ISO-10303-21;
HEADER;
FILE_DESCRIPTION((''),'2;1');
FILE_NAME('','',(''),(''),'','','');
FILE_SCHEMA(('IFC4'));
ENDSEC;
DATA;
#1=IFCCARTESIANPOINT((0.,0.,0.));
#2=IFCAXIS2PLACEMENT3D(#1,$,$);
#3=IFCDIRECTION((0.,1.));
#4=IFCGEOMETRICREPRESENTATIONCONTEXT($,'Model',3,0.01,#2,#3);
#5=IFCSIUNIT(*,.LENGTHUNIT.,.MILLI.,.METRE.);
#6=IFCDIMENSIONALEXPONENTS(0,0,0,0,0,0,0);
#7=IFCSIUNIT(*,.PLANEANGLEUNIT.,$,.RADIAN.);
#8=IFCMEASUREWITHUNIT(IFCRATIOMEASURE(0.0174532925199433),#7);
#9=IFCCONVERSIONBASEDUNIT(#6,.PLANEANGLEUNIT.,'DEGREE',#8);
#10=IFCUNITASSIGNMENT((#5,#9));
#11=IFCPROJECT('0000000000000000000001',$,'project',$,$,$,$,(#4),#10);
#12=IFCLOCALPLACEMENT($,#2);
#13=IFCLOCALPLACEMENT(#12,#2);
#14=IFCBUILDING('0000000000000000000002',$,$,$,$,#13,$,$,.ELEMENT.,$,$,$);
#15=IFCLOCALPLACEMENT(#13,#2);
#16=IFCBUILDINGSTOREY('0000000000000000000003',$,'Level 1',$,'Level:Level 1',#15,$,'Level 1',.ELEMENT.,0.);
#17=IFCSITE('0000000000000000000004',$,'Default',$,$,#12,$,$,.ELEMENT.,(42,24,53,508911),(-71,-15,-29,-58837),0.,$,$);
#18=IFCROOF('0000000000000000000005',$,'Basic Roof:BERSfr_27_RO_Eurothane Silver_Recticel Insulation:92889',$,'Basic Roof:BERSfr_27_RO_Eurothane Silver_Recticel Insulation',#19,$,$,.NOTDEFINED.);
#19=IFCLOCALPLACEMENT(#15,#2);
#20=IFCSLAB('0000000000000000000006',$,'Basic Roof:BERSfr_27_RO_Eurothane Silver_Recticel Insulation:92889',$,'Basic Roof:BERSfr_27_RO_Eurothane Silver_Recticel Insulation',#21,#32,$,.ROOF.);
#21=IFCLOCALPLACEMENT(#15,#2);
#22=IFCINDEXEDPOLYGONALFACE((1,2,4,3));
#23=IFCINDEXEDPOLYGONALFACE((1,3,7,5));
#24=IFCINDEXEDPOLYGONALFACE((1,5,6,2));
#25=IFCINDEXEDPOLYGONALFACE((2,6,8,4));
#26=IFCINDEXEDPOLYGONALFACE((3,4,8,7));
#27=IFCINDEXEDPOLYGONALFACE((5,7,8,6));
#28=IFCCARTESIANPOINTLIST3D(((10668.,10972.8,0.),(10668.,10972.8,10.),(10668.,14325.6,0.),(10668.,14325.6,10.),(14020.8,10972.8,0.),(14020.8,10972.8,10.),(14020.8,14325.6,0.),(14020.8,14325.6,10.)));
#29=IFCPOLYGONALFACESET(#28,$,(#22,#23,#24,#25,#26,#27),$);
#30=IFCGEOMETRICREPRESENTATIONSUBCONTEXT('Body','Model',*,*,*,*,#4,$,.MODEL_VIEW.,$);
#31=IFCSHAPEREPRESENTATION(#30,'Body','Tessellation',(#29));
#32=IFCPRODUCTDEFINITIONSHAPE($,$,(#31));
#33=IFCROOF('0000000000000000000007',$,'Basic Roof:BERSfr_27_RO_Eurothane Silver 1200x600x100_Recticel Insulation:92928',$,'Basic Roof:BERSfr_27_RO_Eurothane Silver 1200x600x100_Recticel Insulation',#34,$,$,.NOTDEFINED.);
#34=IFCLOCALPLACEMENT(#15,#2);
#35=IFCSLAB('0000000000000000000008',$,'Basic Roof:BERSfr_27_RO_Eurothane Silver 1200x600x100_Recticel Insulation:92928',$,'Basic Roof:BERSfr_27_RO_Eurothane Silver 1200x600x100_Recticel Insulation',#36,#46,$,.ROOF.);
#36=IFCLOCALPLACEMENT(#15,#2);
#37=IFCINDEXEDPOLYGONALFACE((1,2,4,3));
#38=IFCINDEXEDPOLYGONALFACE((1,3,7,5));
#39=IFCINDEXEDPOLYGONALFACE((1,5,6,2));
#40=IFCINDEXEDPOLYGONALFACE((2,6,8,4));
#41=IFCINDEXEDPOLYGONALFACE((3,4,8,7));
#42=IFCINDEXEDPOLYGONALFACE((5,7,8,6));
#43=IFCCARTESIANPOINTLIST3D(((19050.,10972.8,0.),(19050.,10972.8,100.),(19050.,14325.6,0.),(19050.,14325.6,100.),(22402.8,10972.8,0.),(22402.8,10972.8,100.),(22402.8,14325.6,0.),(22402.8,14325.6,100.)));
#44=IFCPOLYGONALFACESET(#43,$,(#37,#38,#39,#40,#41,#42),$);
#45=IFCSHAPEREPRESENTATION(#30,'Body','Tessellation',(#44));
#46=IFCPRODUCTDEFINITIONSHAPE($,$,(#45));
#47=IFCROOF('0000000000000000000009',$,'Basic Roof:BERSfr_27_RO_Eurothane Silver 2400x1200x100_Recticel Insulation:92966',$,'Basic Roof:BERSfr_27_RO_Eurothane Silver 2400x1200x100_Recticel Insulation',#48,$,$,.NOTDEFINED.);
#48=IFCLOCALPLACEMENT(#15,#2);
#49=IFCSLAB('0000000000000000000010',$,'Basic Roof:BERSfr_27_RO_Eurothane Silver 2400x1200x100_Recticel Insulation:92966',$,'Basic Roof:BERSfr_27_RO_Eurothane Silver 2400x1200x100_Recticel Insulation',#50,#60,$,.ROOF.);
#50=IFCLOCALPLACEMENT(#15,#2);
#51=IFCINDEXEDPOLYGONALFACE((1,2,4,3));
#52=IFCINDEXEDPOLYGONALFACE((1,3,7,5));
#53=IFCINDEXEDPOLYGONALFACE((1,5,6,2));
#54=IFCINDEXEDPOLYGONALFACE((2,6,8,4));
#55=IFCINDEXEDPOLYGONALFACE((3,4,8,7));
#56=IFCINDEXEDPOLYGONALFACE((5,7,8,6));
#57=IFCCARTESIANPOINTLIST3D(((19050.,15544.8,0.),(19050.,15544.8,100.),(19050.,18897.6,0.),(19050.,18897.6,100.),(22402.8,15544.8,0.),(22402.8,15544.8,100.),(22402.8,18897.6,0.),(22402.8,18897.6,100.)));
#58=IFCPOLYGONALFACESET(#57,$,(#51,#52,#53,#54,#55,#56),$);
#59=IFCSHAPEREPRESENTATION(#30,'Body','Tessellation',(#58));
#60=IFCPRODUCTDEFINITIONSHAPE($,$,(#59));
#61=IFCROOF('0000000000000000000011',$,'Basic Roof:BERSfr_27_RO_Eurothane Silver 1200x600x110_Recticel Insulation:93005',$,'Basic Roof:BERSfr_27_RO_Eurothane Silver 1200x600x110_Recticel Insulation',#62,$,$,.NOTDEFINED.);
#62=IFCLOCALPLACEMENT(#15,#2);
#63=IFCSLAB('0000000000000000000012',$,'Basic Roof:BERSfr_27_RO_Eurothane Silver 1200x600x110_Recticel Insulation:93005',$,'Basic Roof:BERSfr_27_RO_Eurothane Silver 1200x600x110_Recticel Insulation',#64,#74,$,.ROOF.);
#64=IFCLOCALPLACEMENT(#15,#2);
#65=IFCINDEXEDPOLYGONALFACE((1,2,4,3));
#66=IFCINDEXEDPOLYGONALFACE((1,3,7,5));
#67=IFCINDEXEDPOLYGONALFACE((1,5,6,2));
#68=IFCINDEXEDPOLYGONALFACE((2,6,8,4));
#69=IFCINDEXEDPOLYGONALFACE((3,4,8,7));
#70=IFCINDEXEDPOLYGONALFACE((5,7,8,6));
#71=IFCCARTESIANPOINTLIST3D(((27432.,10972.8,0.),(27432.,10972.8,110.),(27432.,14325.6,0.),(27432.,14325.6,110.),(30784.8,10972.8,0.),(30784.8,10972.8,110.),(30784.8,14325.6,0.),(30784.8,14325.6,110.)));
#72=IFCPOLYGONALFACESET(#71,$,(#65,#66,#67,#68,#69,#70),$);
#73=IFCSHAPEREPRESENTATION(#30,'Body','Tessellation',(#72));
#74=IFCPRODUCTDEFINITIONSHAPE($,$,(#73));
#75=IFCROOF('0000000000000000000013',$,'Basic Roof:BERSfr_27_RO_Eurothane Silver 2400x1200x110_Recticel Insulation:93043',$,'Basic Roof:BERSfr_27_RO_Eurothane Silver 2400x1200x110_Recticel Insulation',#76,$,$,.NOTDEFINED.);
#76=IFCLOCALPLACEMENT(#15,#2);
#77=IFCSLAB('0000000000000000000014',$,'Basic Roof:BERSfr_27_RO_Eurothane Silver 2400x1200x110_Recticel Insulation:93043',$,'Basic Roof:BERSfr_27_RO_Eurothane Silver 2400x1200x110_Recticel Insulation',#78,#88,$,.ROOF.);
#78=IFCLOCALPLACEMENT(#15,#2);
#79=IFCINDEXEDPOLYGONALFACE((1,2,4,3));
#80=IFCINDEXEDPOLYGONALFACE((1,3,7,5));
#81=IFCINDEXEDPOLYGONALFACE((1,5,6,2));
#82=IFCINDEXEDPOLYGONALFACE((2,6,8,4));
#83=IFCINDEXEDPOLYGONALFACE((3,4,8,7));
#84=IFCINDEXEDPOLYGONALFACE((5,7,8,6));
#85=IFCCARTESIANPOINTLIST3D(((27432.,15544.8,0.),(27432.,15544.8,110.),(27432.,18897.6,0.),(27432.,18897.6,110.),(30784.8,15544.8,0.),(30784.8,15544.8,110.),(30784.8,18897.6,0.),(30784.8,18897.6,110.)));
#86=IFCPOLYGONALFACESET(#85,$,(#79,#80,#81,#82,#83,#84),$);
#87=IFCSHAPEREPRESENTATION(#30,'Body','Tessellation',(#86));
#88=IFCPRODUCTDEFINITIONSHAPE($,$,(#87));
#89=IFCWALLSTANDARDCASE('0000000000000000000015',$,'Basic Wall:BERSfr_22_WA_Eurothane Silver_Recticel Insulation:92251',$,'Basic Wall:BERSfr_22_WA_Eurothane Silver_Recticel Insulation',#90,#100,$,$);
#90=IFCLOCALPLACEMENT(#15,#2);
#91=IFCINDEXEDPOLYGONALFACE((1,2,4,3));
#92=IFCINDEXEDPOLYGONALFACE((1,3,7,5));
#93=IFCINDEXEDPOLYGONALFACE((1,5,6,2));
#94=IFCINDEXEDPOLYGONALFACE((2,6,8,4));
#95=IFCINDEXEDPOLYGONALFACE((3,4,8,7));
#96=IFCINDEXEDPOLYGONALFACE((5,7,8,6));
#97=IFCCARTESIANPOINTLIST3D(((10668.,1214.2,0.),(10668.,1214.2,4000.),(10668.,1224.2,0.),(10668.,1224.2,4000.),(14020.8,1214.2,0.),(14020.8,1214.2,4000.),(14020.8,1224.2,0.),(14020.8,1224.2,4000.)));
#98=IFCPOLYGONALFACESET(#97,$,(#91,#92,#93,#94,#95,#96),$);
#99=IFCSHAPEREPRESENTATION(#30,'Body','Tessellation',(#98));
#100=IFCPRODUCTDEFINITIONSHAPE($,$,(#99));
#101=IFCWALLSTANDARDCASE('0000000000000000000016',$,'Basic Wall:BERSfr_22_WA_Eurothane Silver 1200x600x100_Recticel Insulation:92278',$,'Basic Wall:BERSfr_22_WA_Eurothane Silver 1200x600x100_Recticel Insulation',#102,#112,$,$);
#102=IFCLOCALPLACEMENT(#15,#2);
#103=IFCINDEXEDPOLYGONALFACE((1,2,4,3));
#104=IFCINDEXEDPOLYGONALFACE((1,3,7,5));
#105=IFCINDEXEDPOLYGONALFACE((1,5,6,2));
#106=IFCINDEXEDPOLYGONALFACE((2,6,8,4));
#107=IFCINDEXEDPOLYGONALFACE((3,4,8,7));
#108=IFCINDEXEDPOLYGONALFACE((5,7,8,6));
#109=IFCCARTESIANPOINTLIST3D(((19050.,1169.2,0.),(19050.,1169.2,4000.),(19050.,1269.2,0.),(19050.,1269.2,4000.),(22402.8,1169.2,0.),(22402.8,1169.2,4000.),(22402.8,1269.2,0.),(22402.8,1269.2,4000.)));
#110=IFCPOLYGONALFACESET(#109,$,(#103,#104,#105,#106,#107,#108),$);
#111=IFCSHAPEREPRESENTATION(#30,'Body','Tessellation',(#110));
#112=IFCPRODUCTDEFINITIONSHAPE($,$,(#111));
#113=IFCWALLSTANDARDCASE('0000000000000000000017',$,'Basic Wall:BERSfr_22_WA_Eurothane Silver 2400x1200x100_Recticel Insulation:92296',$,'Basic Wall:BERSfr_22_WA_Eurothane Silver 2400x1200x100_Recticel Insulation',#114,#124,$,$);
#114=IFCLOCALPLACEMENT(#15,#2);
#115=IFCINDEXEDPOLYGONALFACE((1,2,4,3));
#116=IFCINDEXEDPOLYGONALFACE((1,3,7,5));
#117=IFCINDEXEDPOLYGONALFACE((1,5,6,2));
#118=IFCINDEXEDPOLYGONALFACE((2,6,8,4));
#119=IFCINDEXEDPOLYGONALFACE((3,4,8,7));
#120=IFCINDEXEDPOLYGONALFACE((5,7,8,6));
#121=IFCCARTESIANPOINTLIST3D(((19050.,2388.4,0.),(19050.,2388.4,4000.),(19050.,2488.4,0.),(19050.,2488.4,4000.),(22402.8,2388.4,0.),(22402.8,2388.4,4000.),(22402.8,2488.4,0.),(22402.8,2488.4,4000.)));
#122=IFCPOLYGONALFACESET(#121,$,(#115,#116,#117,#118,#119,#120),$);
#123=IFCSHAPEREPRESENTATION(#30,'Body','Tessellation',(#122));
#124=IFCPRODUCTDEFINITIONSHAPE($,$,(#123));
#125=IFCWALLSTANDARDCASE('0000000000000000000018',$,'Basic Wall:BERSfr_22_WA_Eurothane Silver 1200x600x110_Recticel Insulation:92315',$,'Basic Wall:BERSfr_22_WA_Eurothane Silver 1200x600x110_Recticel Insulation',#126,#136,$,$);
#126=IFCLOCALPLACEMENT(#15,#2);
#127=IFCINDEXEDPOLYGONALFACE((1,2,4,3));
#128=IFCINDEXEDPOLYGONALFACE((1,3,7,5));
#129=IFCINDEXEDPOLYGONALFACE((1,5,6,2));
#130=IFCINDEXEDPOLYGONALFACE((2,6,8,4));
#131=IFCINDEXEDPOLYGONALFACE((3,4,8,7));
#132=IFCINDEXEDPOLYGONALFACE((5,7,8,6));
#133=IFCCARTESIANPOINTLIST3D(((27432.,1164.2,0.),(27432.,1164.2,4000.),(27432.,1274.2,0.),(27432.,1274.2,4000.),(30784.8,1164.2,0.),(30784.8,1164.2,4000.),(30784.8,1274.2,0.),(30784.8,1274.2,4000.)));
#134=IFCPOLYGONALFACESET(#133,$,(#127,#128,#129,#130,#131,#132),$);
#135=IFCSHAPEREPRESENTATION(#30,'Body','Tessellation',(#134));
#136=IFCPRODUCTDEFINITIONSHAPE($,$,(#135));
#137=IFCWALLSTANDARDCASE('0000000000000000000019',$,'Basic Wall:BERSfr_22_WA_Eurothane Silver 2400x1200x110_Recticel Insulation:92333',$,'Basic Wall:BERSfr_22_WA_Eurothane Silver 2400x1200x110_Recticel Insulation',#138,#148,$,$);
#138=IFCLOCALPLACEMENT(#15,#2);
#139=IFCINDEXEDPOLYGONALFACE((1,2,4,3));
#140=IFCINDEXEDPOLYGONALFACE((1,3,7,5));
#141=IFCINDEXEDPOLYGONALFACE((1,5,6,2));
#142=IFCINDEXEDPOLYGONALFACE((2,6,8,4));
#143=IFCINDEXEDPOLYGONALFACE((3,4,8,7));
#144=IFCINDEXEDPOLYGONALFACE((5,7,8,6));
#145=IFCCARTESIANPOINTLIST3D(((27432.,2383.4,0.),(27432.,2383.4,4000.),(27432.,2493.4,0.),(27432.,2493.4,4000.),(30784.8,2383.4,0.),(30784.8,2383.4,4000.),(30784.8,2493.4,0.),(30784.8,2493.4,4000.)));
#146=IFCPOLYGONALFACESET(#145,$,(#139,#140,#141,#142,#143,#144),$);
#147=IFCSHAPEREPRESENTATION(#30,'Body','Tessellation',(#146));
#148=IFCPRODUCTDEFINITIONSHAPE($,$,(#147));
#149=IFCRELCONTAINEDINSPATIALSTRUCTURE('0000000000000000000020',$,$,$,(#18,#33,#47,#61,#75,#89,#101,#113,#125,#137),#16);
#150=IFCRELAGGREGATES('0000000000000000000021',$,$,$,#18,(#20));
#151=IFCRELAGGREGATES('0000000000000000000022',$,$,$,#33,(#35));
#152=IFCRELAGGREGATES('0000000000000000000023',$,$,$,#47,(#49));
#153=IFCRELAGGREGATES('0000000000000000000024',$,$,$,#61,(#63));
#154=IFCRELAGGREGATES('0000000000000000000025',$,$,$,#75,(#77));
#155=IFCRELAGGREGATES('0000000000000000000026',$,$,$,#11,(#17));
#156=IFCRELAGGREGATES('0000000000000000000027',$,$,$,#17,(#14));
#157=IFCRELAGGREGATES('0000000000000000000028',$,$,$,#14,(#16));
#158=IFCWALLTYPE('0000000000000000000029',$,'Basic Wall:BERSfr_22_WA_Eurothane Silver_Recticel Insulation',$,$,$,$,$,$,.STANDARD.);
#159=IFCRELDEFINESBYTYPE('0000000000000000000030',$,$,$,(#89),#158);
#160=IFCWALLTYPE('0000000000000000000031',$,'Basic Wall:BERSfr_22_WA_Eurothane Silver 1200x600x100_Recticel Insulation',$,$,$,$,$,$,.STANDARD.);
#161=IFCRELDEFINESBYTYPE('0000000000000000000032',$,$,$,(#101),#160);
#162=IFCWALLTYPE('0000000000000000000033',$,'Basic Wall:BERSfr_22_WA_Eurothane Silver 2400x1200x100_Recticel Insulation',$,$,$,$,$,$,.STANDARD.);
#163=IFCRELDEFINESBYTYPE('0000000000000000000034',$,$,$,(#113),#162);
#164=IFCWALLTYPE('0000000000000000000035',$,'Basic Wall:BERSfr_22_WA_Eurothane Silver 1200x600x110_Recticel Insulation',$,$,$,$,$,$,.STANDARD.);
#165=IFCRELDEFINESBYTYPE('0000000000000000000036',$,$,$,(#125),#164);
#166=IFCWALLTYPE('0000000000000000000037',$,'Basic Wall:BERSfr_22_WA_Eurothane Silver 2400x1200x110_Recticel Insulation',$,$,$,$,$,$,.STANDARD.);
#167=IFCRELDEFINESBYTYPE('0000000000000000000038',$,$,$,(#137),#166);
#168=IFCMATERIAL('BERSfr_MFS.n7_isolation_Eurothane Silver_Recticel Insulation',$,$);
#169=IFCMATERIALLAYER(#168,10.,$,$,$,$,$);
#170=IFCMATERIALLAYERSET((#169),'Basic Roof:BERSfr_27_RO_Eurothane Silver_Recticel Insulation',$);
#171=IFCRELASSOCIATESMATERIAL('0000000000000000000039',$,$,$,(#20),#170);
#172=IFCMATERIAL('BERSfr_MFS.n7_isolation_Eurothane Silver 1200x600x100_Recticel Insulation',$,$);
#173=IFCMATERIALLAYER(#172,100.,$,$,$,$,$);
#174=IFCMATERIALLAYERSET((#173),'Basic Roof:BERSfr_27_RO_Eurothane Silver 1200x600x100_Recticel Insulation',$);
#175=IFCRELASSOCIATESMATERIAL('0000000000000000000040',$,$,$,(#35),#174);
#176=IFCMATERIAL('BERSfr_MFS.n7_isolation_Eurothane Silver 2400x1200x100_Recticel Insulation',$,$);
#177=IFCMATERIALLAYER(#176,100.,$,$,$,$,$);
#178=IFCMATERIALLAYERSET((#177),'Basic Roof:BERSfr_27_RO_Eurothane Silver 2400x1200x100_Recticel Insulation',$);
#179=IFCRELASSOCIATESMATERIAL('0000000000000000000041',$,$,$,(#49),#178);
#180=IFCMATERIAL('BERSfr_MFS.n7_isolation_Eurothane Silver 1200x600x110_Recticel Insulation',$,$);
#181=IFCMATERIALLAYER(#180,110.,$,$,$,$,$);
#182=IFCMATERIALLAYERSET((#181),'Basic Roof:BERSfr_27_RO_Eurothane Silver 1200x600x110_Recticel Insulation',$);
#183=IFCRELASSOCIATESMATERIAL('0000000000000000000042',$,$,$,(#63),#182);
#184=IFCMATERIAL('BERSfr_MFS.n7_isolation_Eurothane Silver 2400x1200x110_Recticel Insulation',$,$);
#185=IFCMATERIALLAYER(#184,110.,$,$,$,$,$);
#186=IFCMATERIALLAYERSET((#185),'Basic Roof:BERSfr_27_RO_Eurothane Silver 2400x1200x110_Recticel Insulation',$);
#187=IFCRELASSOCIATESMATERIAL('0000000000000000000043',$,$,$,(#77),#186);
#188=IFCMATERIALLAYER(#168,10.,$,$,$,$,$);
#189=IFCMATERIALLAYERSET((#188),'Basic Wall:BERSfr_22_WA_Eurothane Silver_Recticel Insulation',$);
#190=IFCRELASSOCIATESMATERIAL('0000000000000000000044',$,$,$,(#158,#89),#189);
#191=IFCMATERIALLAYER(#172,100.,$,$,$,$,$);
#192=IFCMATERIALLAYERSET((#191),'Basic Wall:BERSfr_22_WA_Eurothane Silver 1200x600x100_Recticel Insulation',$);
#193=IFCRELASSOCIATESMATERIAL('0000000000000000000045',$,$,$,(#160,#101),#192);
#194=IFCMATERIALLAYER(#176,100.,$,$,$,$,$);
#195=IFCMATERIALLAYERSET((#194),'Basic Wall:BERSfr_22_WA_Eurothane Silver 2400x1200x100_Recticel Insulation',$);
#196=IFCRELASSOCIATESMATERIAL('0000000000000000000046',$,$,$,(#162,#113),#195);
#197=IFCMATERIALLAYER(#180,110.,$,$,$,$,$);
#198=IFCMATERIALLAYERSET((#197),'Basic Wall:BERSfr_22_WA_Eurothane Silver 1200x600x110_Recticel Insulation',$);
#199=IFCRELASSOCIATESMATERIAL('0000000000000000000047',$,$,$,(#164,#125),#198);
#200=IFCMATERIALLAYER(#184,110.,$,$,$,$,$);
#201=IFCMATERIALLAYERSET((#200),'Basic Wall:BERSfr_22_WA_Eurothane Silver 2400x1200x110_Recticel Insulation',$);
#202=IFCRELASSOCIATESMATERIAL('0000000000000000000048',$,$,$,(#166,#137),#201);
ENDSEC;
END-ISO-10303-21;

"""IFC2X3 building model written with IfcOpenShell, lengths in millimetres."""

from ifc_helpers import new_model, entity, si_unit, converted_unit, direction, frame, frame_2d, origin, place, context, subcontext, project, spatial, rectangle, extrude, material, layer, layer_set, layer_usage, type_object, element, aggregate, save


model = new_model("IFC2X3")

# Units and contexts
model_context = context("Model", 3, precision=0.01, world=origin(), true_north=direction((0.0, 1.0)))
body_context = subcontext(model_context, "Body", "Model", "MODEL_VIEW")
ifc_project = project(units=[si_unit("LENGTHUNIT", "METRE", prefix="MILLI"), converted_unit("PLANEANGLEUNIT", "DEGREE", entity("IfcRatioMeasure", 0.0174532925199433), si_unit("PLANEANGLEUNIT", "RADIAN"), dimensions=[0, 0, 0, 0, 0, 0, 0])], contexts=[model_context])

# Site, building, storey
site_placement = place(None, origin())
site = spatial("IfcSite", under=ifc_project, at=site_placement, Name="Default", CompositionType="ELEMENT", RefLatitude=(42, 24, 53, 508911), RefLongitude=(-71, -15, -29, -58837), RefElevation=0.0)
building_placement = place(site_placement, origin())
building = spatial("IfcBuilding", under=site, at=building_placement, CompositionType="ELEMENT")
storey_placement = place(building_placement, origin())
storey = spatial("IfcBuildingStorey", under=building, at=storey_placement, Name="Level 1", ObjectType="Level:Level 1", LongName="Level 1", CompositionType="ELEMENT", Elevation=0.0)

# Roofs, slabs
roof_1_placement = place(storey_placement, frame((10668.0, 10972.8, 0.0)))
roof_1 = element("IfcRoof", 1, at=roof_1_placement, inside=storey, Name="Basic Roof:BERSfr_27_RO_Eurothane Silver_Recticel Insulation:92889", ObjectType="Basic Roof:BERSfr_27_RO_Eurothane Silver_Recticel Insulation", ShapeType="NOTDEFINED")
ifc_material_1 = material(Name="BERSfr_MFS.n7_isolation_Eurothane Silver_Recticel Insulation")
ifc_layer_1 = layer(ifc_material_1, 10.0)
ifc_layer_set_1 = layer_set([ifc_layer_1], Name="Basic Roof:BERSfr_27_RO_Eurothane Silver_Recticel Insulation")
slab_1_placement = place(roof_1_placement, origin())
slab_1 = element("IfcSlab", 2, at=slab_1_placement, material=ifc_layer_set_1, Name="Basic Roof:BERSfr_27_RO_Eurothane Silver_Recticel Insulation:92889", ObjectType="Basic Roof:BERSfr_27_RO_Eurothane Silver_Recticel Insulation", PredefinedType="ROOF", context=body_context, shape_type="SweptSolid", body=[
    extrude(rectangle(XDim=3352.8, YDim=3352.8, at=frame_2d((0.0, 0.0), x_axis=(-1.0, 0.0))), frame((1676.4, 1676.4, 0.0)), (0.0, 0.0, 1.0), 10.0),
])
aggregate(roof_1, [slab_1])
roof_2_placement = place(storey_placement, frame((19050.0, 10972.8, 0.0)))
roof_2 = element("IfcRoof", 3, at=roof_2_placement, inside=storey, Name="Basic Roof:BERSfr_27_RO_Eurothane Silver 1200x600x100_Recticel Insulation:92928", ObjectType="Basic Roof:BERSfr_27_RO_Eurothane Silver 1200x600x100_Recticel Insulation", ShapeType="NOTDEFINED")
ifc_material_2 = material(Name="BERSfr_MFS.n7_isolation_Eurothane Silver 1200x600x100_Recticel Insulation")
ifc_layer_2 = layer(ifc_material_2, 100.0)
ifc_layer_set_2 = layer_set([ifc_layer_2], Name="Basic Roof:BERSfr_27_RO_Eurothane Silver 1200x600x100_Recticel Insulation")
slab_2_placement = place(roof_2_placement, origin())
slab_2 = element("IfcSlab", 4, at=slab_2_placement, material=ifc_layer_set_2, Name="Basic Roof:BERSfr_27_RO_Eurothane Silver 1200x600x100_Recticel Insulation:92928", ObjectType="Basic Roof:BERSfr_27_RO_Eurothane Silver 1200x600x100_Recticel Insulation", PredefinedType="ROOF", context=body_context, shape_type="SweptSolid", body=[
    extrude(rectangle(XDim=3352.8, YDim=3352.8, at=frame_2d((0.0, 0.0), x_axis=(-1.0, 0.0))), frame((1676.4, 1676.4, 0.0)), (0.0, 0.0, 1.0), 100.0),
])
aggregate(roof_2, [slab_2])
roof_3_placement = place(storey_placement, frame((19050.0, 15544.8, 0.0)))
roof_3 = element("IfcRoof", 5, at=roof_3_placement, inside=storey, Name="Basic Roof:BERSfr_27_RO_Eurothane Silver 2400x1200x100_Recticel Insulation:92966", ObjectType="Basic Roof:BERSfr_27_RO_Eurothane Silver 2400x1200x100_Recticel Insulation", ShapeType="NOTDEFINED")
ifc_material_3 = material(Name="BERSfr_MFS.n7_isolation_Eurothane Silver 2400x1200x100_Recticel Insulation")
ifc_layer_3 = layer(ifc_material_3, 100.0)
ifc_layer_set_3 = layer_set([ifc_layer_3], Name="Basic Roof:BERSfr_27_RO_Eurothane Silver 2400x1200x100_Recticel Insulation")
slab_3_placement = place(roof_3_placement, origin())
slab_3 = element("IfcSlab", 6, at=slab_3_placement, material=ifc_layer_set_3, Name="Basic Roof:BERSfr_27_RO_Eurothane Silver 2400x1200x100_Recticel Insulation:92966", ObjectType="Basic Roof:BERSfr_27_RO_Eurothane Silver 2400x1200x100_Recticel Insulation", PredefinedType="ROOF", context=body_context, shape_type="SweptSolid", body=[
    extrude(rectangle(XDim=3352.8, YDim=3352.8, at=frame_2d((0.0, 0.0), x_axis=(-1.0, 0.0))), frame((1676.4, 1676.4, 0.0)), (0.0, 0.0, 1.0), 100.0),
])
aggregate(roof_3, [slab_3])
roof_4_placement = place(storey_placement, frame((27432.0, 10972.8, 0.0)))
roof_4 = element("IfcRoof", 7, at=roof_4_placement, inside=storey, Name="Basic Roof:BERSfr_27_RO_Eurothane Silver 1200x600x110_Recticel Insulation:93005", ObjectType="Basic Roof:BERSfr_27_RO_Eurothane Silver 1200x600x110_Recticel Insulation", ShapeType="NOTDEFINED")
ifc_material_4 = material(Name="BERSfr_MFS.n7_isolation_Eurothane Silver 1200x600x110_Recticel Insulation")
ifc_layer_4 = layer(ifc_material_4, 110.0)
ifc_layer_set_4 = layer_set([ifc_layer_4], Name="Basic Roof:BERSfr_27_RO_Eurothane Silver 1200x600x110_Recticel Insulation")
slab_4_placement = place(roof_4_placement, origin())
slab_4 = element("IfcSlab", 8, at=slab_4_placement, material=ifc_layer_set_4, Name="Basic Roof:BERSfr_27_RO_Eurothane Silver 1200x600x110_Recticel Insulation:93005", ObjectType="Basic Roof:BERSfr_27_RO_Eurothane Silver 1200x600x110_Recticel Insulation", PredefinedType="ROOF", context=body_context, shape_type="SweptSolid", body=[
    extrude(rectangle(XDim=3352.8, YDim=3352.8, at=frame_2d((0.0, 0.0), x_axis=(-1.0, 0.0))), frame((1676.4, 1676.4, 0.0)), (0.0, 0.0, 1.0), 110.0),
])
aggregate(roof_4, [slab_4])
roof_5_placement = place(storey_placement, frame((27432.0, 15544.8, 0.0)))
roof_5 = element("IfcRoof", 9, at=roof_5_placement, inside=storey, Name="Basic Roof:BERSfr_27_RO_Eurothane Silver 2400x1200x110_Recticel Insulation:93043", ObjectType="Basic Roof:BERSfr_27_RO_Eurothane Silver 2400x1200x110_Recticel Insulation", ShapeType="NOTDEFINED")
ifc_material_5 = material(Name="BERSfr_MFS.n7_isolation_Eurothane Silver 2400x1200x110_Recticel Insulation")
ifc_layer_5 = layer(ifc_material_5, 110.0)
ifc_layer_set_5 = layer_set([ifc_layer_5], Name="Basic Roof:BERSfr_27_RO_Eurothane Silver 2400x1200x110_Recticel Insulation")
slab_5_placement = place(roof_5_placement, origin())
slab_5 = element("IfcSlab", 10, at=slab_5_placement, material=ifc_layer_set_5, Name="Basic Roof:BERSfr_27_RO_Eurothane Silver 2400x1200x110_Recticel Insulation:93043", ObjectType="Basic Roof:BERSfr_27_RO_Eurothane Silver 2400x1200x110_Recticel Insulation", PredefinedType="ROOF", context=body_context, shape_type="SweptSolid", body=[
    extrude(rectangle(XDim=3352.8, YDim=3352.8, at=frame_2d((0.0, 0.0), x_axis=(-1.0, 0.0))), frame((1676.4, 1676.4, 0.0)), (0.0, 0.0, 1.0), 110.0),
])
aggregate(roof_5, [slab_5])

# Walls
ifc_layer_6 = layer(ifc_material_1, 10.0)
ifc_layer_set_6 = layer_set([ifc_layer_6], Name="Basic Wall:BERSfr_22_WA_Eurothane Silver_Recticel Insulation")
ifc_layer_usage_1 = layer_usage(ifc_layer_set_6, "AXIS2", "NEGATIVE", 5.0)
wall_type_1 = type_object("IfcWallType", Name="Basic Wall:BERSfr_22_WA_Eurothane Silver_Recticel Insulation", PredefinedType="STANDARD", material=ifc_layer_set_6)
wall_1_placement = place(storey_placement, frame((10668.0, 1219.2, 0.0)))
element("IfcWallStandardCase", 11, at=wall_1_placement, inside=storey, type_object=wall_type_1, material=ifc_layer_usage_1, Name="Basic Wall:BERSfr_22_WA_Eurothane Silver_Recticel Insulation:92251", ObjectType="Basic Wall:BERSfr_22_WA_Eurothane Silver_Recticel Insulation", context=body_context, shape_type="SweptSolid", body=[
    extrude(rectangle(XDim=3352.8, YDim=10.0, at=frame_2d((1676.4, 0.0), x_axis=(-1.0, 0.0))), origin(), (0.0, 0.0, 1.0), 4000.0),
])
ifc_layer_7 = layer(ifc_material_2, 100.0)
ifc_layer_set_7 = layer_set([ifc_layer_7], Name="Basic Wall:BERSfr_22_WA_Eurothane Silver 1200x600x100_Recticel Insulation")
ifc_layer_usage_2 = layer_usage(ifc_layer_set_7, "AXIS2", "NEGATIVE", 50.0)
wall_type_2 = type_object("IfcWallType", Name="Basic Wall:BERSfr_22_WA_Eurothane Silver 1200x600x100_Recticel Insulation", PredefinedType="STANDARD", material=ifc_layer_set_7)
wall_2_placement = place(storey_placement, frame((19050.0, 1219.2, 0.0)))
element("IfcWallStandardCase", 12, at=wall_2_placement, inside=storey, type_object=wall_type_2, material=ifc_layer_usage_2, Name="Basic Wall:BERSfr_22_WA_Eurothane Silver 1200x600x100_Recticel Insulation:92278", ObjectType="Basic Wall:BERSfr_22_WA_Eurothane Silver 1200x600x100_Recticel Insulation", context=body_context, shape_type="SweptSolid", body=[
    extrude(rectangle(XDim=3352.8, YDim=100.0, at=frame_2d((1676.4, 0.0), x_axis=(-1.0, 0.0))), origin(), (0.0, 0.0, 1.0), 4000.0),
])
ifc_layer_8 = layer(ifc_material_3, 100.0)
ifc_layer_set_8 = layer_set([ifc_layer_8], Name="Basic Wall:BERSfr_22_WA_Eurothane Silver 2400x1200x100_Recticel Insulation")
ifc_layer_usage_3 = layer_usage(ifc_layer_set_8, "AXIS2", "NEGATIVE", 50.0)
wall_type_3 = type_object("IfcWallType", Name="Basic Wall:BERSfr_22_WA_Eurothane Silver 2400x1200x100_Recticel Insulation", PredefinedType="STANDARD", material=ifc_layer_set_8)
wall_3_placement = place(storey_placement, frame((19050.0, 2438.4, 0.0)))
element("IfcWallStandardCase", 13, at=wall_3_placement, inside=storey, type_object=wall_type_3, material=ifc_layer_usage_3, Name="Basic Wall:BERSfr_22_WA_Eurothane Silver 2400x1200x100_Recticel Insulation:92296", ObjectType="Basic Wall:BERSfr_22_WA_Eurothane Silver 2400x1200x100_Recticel Insulation", context=body_context, shape_type="SweptSolid", body=[
    extrude(rectangle(XDim=3352.8, YDim=100.0, at=frame_2d((1676.4, 0.0), x_axis=(-1.0, 0.0))), origin(), (0.0, 0.0, 1.0), 4000.0),
])
ifc_layer_9 = layer(ifc_material_4, 110.0)
ifc_layer_set_9 = layer_set([ifc_layer_9], Name="Basic Wall:BERSfr_22_WA_Eurothane Silver 1200x600x110_Recticel Insulation")
ifc_layer_usage_4 = layer_usage(ifc_layer_set_9, "AXIS2", "NEGATIVE", 55.0)
wall_type_4 = type_object("IfcWallType", Name="Basic Wall:BERSfr_22_WA_Eurothane Silver 1200x600x110_Recticel Insulation", PredefinedType="STANDARD", material=ifc_layer_set_9)
wall_4_placement = place(storey_placement, frame((27432.0, 1219.2, 0.0)))
element("IfcWallStandardCase", 14, at=wall_4_placement, inside=storey, type_object=wall_type_4, material=ifc_layer_usage_4, Name="Basic Wall:BERSfr_22_WA_Eurothane Silver 1200x600x110_Recticel Insulation:92315", ObjectType="Basic Wall:BERSfr_22_WA_Eurothane Silver 1200x600x110_Recticel Insulation", context=body_context, shape_type="SweptSolid", body=[
    extrude(rectangle(XDim=3352.8, YDim=110.0, at=frame_2d((1676.4, 0.0), x_axis=(-1.0, 0.0))), origin(), (0.0, 0.0, 1.0), 4000.0),
])
ifc_layer_10 = layer(ifc_material_5, 110.0)
ifc_layer_set_10 = layer_set([ifc_layer_10], Name="Basic Wall:BERSfr_22_WA_Eurothane Silver 2400x1200x110_Recticel Insulation")
ifc_layer_usage_5 = layer_usage(ifc_layer_set_10, "AXIS2", "NEGATIVE", 55.0)
wall_type_5 = type_object("IfcWallType", Name="Basic Wall:BERSfr_22_WA_Eurothane Silver 2400x1200x110_Recticel Insulation", PredefinedType="STANDARD", material=ifc_layer_set_10)
wall_5_placement = place(storey_placement, frame((27432.0, 2438.4, 0.0)))
element("IfcWallStandardCase", 15, at=wall_5_placement, inside=storey, type_object=wall_type_5, material=ifc_layer_usage_5, Name="Basic Wall:BERSfr_22_WA_Eurothane Silver 2400x1200x110_Recticel Insulation:92333", ObjectType="Basic Wall:BERSfr_22_WA_Eurothane Silver 2400x1200x110_Recticel Insulation", context=body_context, shape_type="SweptSolid", body=[
    extrude(rectangle(XDim=3352.8, YDim=110.0, at=frame_2d((1676.4, 0.0), x_axis=(-1.0, 0.0))), origin(), (0.0, 0.0, 1.0), 4000.0),
])

save(model, "model.ifc")
